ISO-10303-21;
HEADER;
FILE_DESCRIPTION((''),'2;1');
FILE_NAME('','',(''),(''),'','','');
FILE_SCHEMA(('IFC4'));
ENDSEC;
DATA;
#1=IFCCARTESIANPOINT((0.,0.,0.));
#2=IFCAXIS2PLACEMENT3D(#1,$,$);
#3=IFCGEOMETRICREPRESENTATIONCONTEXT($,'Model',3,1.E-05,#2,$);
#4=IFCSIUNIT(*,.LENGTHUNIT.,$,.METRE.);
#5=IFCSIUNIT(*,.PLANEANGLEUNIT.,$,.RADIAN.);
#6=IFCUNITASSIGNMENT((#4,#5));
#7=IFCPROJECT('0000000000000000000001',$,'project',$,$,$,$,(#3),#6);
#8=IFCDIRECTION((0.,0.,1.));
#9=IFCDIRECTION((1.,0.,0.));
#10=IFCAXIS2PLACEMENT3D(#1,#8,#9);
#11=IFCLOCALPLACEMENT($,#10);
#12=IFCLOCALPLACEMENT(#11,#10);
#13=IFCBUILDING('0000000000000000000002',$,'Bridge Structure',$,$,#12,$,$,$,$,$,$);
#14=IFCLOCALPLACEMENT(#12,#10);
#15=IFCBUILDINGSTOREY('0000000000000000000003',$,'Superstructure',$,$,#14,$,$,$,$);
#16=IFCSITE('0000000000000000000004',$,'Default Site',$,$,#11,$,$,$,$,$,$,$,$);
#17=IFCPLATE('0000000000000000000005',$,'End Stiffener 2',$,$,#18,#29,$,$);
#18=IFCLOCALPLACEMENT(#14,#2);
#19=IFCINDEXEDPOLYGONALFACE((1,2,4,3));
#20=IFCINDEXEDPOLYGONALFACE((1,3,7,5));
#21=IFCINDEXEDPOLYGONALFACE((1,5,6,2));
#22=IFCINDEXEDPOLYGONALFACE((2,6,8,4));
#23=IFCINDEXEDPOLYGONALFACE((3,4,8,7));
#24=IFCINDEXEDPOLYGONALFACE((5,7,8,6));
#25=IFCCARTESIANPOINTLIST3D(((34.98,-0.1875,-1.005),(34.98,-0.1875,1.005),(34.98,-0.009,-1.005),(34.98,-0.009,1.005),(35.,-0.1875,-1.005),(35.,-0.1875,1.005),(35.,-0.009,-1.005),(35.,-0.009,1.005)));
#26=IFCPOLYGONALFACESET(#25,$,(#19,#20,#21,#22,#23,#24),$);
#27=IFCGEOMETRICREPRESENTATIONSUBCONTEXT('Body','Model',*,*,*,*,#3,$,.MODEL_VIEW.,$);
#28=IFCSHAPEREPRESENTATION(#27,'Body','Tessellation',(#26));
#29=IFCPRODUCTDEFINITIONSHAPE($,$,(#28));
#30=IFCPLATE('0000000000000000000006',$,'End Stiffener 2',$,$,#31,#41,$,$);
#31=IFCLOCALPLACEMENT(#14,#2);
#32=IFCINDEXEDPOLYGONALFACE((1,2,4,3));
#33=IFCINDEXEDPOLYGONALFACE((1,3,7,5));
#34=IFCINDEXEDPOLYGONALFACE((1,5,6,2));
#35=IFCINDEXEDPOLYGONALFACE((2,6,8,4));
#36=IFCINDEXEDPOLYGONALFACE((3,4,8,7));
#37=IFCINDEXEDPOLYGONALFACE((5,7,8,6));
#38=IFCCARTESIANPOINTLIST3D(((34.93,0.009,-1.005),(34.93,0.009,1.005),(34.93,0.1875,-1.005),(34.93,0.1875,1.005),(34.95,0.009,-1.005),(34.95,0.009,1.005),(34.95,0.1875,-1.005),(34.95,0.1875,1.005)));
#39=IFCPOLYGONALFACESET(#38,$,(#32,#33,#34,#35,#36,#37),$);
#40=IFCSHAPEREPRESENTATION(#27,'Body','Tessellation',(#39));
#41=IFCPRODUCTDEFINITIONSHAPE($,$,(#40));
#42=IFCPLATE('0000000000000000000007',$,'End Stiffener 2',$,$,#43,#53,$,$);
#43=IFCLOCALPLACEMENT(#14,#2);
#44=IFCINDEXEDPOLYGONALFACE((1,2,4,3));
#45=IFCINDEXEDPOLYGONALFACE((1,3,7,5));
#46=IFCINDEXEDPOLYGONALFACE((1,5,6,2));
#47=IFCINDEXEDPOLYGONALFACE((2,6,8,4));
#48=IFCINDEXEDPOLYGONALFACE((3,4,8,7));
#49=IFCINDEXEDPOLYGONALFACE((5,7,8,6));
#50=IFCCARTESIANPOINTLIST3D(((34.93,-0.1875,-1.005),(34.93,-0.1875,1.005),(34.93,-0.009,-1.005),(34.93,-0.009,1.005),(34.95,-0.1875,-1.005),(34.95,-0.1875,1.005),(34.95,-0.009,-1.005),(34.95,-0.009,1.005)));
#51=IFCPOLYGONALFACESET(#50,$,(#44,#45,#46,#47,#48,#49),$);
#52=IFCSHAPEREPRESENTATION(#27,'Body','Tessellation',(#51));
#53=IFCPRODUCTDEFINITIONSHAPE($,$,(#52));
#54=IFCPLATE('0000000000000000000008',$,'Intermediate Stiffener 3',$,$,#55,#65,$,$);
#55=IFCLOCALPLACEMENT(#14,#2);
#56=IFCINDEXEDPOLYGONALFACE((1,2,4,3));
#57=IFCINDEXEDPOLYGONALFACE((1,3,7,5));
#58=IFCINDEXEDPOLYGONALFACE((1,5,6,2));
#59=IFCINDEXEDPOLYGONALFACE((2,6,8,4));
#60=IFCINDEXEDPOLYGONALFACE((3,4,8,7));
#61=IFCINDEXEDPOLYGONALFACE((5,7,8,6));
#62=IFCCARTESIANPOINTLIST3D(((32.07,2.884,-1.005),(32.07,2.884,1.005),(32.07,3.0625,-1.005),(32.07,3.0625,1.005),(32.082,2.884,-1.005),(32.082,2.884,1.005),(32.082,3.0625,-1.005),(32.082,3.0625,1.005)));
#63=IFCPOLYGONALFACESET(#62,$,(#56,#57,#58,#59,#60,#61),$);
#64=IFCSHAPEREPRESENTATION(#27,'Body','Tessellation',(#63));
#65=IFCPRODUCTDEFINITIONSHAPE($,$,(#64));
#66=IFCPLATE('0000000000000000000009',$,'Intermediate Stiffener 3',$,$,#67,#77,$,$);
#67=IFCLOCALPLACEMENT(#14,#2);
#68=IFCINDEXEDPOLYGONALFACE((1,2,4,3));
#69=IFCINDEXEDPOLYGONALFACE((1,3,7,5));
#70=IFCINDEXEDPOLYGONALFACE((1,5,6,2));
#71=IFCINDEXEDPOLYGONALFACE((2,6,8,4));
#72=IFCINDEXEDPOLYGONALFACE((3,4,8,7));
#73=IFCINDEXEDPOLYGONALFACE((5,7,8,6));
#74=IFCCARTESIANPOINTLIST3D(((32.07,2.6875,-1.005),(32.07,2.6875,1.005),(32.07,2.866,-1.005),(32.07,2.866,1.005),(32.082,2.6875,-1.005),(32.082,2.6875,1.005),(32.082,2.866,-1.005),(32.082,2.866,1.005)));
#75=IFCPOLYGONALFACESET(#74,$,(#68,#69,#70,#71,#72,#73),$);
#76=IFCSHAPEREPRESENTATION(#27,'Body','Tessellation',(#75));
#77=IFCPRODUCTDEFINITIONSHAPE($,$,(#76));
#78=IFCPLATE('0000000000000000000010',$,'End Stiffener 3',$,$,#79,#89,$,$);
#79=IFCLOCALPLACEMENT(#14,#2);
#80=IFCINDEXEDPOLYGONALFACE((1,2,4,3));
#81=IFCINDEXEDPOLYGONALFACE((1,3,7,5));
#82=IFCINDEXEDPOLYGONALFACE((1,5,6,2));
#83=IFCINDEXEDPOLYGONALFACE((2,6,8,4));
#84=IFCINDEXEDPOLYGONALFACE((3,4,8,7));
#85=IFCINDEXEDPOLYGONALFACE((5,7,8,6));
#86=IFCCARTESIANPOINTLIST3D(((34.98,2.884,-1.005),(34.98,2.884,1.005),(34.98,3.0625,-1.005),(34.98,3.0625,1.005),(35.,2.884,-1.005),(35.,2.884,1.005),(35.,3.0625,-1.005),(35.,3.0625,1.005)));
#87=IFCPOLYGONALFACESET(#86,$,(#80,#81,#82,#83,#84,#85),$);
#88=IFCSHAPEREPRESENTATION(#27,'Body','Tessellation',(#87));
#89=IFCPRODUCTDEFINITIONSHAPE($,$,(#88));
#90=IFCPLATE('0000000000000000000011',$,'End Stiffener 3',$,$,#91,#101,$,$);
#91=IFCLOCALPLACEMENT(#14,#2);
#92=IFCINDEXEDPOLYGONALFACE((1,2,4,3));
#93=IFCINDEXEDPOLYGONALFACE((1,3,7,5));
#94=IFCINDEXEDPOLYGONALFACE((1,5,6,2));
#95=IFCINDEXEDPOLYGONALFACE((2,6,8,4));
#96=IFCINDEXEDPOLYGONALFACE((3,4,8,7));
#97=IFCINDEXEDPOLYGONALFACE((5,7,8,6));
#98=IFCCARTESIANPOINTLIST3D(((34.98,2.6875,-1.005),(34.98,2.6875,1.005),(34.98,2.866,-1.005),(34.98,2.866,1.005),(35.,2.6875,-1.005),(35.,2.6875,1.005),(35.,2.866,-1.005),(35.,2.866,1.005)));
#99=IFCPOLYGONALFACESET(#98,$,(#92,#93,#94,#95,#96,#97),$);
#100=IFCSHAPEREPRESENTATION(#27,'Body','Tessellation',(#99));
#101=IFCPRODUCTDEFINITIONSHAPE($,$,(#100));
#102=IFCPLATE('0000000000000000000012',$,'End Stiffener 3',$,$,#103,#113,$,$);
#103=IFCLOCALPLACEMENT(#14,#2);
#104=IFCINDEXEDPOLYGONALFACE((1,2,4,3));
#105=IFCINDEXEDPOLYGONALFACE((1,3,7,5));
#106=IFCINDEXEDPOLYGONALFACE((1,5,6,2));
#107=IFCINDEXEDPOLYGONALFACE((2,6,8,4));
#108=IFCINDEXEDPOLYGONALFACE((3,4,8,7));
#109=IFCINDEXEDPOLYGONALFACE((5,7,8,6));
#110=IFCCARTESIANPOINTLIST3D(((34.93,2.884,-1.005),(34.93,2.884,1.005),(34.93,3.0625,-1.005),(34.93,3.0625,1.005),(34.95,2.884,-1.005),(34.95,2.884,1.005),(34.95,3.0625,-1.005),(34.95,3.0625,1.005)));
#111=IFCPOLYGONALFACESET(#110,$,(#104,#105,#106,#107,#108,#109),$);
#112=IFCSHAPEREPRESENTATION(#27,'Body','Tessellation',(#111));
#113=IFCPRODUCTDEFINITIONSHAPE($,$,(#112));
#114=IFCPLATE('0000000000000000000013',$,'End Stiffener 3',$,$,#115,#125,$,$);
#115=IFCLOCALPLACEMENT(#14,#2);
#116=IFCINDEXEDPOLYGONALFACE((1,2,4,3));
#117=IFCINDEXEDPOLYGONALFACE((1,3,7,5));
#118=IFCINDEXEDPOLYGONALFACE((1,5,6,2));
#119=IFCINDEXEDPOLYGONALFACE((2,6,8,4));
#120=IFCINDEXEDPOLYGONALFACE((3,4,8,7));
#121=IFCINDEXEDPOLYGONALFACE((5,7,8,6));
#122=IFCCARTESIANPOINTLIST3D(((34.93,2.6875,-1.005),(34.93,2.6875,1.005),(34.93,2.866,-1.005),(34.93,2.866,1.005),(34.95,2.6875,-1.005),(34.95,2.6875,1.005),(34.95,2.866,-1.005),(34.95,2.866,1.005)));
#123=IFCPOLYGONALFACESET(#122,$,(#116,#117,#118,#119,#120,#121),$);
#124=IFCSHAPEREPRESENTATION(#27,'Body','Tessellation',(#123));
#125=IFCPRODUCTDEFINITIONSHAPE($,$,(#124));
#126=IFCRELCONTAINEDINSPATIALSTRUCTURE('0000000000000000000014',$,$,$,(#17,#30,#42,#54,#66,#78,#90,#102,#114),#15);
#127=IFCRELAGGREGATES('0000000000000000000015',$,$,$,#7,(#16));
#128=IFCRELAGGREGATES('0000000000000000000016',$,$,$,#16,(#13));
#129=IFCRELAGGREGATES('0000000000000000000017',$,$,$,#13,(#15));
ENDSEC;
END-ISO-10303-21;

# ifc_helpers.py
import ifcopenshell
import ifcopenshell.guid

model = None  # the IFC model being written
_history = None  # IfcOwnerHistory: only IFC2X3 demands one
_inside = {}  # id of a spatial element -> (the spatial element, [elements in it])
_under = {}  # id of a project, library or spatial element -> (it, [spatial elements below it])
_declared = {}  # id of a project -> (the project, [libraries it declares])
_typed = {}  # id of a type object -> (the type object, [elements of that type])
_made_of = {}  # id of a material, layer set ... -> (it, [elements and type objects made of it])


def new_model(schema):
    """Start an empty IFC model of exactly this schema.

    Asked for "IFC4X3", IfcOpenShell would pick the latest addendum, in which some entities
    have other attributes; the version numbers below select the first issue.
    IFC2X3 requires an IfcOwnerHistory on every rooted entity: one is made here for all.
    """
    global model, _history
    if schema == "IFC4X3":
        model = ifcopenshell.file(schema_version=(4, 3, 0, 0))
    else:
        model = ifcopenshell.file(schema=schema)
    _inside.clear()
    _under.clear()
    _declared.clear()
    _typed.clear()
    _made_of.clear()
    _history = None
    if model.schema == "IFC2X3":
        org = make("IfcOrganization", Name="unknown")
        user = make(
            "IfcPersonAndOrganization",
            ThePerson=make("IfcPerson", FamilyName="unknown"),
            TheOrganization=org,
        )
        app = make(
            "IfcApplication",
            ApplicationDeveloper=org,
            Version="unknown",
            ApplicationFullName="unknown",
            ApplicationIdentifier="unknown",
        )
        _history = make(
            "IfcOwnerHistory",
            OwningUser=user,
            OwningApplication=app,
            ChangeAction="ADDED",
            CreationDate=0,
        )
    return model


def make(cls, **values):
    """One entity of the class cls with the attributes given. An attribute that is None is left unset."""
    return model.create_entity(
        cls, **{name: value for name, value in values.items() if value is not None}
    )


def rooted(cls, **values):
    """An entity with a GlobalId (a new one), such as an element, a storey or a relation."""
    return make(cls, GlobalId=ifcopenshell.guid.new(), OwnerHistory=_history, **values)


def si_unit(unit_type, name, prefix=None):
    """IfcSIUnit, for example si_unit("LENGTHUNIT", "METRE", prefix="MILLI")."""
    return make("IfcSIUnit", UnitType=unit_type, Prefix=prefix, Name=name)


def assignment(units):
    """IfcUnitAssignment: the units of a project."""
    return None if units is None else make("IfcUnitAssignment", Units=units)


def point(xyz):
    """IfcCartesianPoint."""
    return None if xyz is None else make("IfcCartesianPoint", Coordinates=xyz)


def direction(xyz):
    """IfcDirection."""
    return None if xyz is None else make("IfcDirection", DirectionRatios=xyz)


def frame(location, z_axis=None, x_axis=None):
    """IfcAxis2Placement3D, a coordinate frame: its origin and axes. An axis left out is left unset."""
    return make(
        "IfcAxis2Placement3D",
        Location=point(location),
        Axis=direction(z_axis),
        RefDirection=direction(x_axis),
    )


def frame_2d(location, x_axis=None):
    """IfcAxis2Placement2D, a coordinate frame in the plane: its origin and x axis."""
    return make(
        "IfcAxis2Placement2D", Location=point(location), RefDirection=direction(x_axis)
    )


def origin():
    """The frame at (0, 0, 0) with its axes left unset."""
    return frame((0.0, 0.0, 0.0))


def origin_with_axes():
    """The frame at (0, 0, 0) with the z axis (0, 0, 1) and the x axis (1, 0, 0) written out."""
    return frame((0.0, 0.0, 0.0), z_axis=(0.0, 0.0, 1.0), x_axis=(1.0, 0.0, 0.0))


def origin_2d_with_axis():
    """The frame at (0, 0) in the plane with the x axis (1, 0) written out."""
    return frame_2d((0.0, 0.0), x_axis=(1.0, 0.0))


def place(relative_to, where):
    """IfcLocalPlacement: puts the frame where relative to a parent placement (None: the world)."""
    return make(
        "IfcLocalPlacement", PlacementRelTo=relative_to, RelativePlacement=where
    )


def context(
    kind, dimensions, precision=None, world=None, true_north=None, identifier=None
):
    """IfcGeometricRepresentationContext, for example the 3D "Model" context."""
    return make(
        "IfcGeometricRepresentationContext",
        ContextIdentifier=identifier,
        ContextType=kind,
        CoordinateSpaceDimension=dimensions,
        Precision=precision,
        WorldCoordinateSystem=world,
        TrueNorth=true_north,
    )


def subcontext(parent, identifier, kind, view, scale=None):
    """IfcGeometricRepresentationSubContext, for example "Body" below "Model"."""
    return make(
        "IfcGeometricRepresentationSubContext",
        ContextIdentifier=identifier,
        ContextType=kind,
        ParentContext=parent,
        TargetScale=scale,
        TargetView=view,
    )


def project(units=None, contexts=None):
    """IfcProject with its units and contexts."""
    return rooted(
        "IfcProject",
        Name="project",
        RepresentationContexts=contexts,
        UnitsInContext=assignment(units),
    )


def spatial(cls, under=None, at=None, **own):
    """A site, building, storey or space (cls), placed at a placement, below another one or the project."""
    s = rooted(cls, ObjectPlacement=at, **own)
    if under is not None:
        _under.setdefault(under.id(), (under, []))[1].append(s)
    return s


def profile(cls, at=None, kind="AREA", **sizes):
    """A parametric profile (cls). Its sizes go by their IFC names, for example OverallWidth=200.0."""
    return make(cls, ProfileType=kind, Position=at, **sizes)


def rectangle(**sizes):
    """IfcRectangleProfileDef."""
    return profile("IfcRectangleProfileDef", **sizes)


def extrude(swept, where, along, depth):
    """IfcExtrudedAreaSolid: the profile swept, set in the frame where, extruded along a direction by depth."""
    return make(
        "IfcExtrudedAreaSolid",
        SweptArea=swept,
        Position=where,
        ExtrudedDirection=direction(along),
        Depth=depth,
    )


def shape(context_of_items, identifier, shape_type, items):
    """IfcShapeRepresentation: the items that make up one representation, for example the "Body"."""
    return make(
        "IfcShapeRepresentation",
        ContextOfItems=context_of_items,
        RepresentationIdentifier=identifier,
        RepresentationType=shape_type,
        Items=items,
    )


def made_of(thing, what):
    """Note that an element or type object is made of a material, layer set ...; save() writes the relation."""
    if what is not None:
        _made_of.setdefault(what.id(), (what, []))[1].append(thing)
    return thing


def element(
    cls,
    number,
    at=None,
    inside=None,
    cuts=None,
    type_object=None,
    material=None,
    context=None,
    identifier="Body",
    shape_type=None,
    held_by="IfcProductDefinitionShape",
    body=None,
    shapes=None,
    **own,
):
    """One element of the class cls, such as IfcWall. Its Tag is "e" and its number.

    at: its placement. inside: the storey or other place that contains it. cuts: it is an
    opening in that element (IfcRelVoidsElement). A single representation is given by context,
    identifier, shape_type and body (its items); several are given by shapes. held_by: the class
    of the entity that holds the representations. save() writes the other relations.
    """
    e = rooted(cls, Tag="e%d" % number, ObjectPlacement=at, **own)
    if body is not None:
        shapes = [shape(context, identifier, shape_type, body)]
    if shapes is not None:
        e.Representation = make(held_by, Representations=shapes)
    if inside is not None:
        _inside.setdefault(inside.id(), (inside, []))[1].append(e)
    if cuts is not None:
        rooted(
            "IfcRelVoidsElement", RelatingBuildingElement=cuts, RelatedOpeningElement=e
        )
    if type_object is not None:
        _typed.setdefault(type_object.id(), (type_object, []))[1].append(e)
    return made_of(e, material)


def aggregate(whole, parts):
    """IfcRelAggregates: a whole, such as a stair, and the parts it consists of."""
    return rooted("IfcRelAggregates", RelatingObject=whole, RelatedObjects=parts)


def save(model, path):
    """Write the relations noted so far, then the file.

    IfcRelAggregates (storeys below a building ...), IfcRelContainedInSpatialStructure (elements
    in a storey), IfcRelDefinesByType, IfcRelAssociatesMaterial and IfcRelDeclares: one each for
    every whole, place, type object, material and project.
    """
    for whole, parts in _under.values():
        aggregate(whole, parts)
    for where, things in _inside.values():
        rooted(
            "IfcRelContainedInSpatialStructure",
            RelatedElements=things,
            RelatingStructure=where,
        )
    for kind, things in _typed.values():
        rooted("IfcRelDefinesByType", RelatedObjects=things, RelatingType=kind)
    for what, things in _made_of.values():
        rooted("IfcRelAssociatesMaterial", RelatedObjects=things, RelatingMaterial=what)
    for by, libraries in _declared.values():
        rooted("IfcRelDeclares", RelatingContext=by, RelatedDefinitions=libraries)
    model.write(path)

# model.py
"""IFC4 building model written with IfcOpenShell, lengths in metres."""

from ifc_helpers import new_model, si_unit, frame, origin, origin_with_axes, origin_2d_with_axis, place, context, subcontext, project, spatial, rectangle, extrude, element, save


model = new_model("IFC4")

# Units and contexts
model_context = context("Model", 3, precision=1e-05, world=origin())
body_context = subcontext(model_context, "Body", "Model", "MODEL_VIEW")
ifc_project = project(units=[si_unit("LENGTHUNIT", "METRE"), si_unit("PLANEANGLEUNIT", "RADIAN")], contexts=[model_context])

# Site, building, storey
site_placement = place(None, origin_with_axes())
site = spatial("IfcSite", under=ifc_project, at=site_placement, Name="Default Site")
building_placement = place(site_placement, origin_with_axes())
building = spatial("IfcBuilding", under=site, at=building_placement, Name="Bridge Structure")
storey_placement = place(building_placement, origin_with_axes())
storey = spatial("IfcBuildingStorey", under=building, at=storey_placement, Name="Superstructure")

# Plates
for number, where, z_axis, x_axis, name in (
    (1, (34.99, -0.0983, -1.005), (0.0, 0.0, 1.0), (1.0, 0.0, 0.0), "End Stiffener 2"),
    (2, (34.94, 0.0983, -1.005), (0.0, 0.0, 1.0), (1.0, 0.0, 0.0), "End Stiffener 2"),
    (3, (34.94, -0.0983, -1.005), (0.0, 0.0, 1.0), (1.0, 0.0, 0.0), "End Stiffener 2"),
):
    element("IfcPlate", number, at=place(storey_placement, frame(where, z_axis=z_axis, x_axis=x_axis)), inside=storey, Name=name, context=body_context, shape_type="SweptSolid", body=[
        extrude(rectangle(XDim=0.02, YDim=0.1785, at=origin_2d_with_axis()), origin_with_axes(), (0.0, 0.0, 1.0), 2.01),
    ])
for number, where, z_axis, x_axis, name in (
    (4, (32.076, 2.9733, -1.005), (0.0, 0.0, 1.0), (1.0, 0.0, 0.0), "Intermediate Stiffener 3"),
    (5, (32.076, 2.7768, -1.005), (0.0, 0.0, 1.0), (1.0, 0.0, 0.0), "Intermediate Stiffener 3"),
):
    element("IfcPlate", number, at=place(storey_placement, frame(where, z_axis=z_axis, x_axis=x_axis)), inside=storey, Name=name, context=body_context, shape_type="SweptSolid", body=[
        extrude(rectangle(XDim=0.012, YDim=0.1785, at=origin_2d_with_axis()), origin_with_axes(), (0.0, 0.0, 1.0), 2.01),
    ])
for number, where, z_axis, x_axis, name in (
    (6, (34.99, 2.9733, -1.005), (0.0, 0.0, 1.0), (1.0, 0.0, 0.0), "End Stiffener 3"),
    (7, (34.99, 2.7768, -1.005), (0.0, 0.0, 1.0), (1.0, 0.0, 0.0), "End Stiffener 3"),
    (8, (34.94, 2.9733, -1.005), (0.0, 0.0, 1.0), (1.0, 0.0, 0.0), "End Stiffener 3"),
    (9, (34.94, 2.7768, -1.005), (0.0, 0.0, 1.0), (1.0, 0.0, 0.0), "End Stiffener 3"),
):
    element("IfcPlate", number, at=place(storey_placement, frame(where, z_axis=z_axis, x_axis=x_axis)), inside=storey, Name=name, context=body_context, shape_type="SweptSolid", body=[
        extrude(rectangle(XDim=0.02, YDim=0.1785, at=origin_2d_with_axis()), origin_with_axes(), (0.0, 0.0, 1.0), 2.01),
    ])

save(model, "model.ifc")
